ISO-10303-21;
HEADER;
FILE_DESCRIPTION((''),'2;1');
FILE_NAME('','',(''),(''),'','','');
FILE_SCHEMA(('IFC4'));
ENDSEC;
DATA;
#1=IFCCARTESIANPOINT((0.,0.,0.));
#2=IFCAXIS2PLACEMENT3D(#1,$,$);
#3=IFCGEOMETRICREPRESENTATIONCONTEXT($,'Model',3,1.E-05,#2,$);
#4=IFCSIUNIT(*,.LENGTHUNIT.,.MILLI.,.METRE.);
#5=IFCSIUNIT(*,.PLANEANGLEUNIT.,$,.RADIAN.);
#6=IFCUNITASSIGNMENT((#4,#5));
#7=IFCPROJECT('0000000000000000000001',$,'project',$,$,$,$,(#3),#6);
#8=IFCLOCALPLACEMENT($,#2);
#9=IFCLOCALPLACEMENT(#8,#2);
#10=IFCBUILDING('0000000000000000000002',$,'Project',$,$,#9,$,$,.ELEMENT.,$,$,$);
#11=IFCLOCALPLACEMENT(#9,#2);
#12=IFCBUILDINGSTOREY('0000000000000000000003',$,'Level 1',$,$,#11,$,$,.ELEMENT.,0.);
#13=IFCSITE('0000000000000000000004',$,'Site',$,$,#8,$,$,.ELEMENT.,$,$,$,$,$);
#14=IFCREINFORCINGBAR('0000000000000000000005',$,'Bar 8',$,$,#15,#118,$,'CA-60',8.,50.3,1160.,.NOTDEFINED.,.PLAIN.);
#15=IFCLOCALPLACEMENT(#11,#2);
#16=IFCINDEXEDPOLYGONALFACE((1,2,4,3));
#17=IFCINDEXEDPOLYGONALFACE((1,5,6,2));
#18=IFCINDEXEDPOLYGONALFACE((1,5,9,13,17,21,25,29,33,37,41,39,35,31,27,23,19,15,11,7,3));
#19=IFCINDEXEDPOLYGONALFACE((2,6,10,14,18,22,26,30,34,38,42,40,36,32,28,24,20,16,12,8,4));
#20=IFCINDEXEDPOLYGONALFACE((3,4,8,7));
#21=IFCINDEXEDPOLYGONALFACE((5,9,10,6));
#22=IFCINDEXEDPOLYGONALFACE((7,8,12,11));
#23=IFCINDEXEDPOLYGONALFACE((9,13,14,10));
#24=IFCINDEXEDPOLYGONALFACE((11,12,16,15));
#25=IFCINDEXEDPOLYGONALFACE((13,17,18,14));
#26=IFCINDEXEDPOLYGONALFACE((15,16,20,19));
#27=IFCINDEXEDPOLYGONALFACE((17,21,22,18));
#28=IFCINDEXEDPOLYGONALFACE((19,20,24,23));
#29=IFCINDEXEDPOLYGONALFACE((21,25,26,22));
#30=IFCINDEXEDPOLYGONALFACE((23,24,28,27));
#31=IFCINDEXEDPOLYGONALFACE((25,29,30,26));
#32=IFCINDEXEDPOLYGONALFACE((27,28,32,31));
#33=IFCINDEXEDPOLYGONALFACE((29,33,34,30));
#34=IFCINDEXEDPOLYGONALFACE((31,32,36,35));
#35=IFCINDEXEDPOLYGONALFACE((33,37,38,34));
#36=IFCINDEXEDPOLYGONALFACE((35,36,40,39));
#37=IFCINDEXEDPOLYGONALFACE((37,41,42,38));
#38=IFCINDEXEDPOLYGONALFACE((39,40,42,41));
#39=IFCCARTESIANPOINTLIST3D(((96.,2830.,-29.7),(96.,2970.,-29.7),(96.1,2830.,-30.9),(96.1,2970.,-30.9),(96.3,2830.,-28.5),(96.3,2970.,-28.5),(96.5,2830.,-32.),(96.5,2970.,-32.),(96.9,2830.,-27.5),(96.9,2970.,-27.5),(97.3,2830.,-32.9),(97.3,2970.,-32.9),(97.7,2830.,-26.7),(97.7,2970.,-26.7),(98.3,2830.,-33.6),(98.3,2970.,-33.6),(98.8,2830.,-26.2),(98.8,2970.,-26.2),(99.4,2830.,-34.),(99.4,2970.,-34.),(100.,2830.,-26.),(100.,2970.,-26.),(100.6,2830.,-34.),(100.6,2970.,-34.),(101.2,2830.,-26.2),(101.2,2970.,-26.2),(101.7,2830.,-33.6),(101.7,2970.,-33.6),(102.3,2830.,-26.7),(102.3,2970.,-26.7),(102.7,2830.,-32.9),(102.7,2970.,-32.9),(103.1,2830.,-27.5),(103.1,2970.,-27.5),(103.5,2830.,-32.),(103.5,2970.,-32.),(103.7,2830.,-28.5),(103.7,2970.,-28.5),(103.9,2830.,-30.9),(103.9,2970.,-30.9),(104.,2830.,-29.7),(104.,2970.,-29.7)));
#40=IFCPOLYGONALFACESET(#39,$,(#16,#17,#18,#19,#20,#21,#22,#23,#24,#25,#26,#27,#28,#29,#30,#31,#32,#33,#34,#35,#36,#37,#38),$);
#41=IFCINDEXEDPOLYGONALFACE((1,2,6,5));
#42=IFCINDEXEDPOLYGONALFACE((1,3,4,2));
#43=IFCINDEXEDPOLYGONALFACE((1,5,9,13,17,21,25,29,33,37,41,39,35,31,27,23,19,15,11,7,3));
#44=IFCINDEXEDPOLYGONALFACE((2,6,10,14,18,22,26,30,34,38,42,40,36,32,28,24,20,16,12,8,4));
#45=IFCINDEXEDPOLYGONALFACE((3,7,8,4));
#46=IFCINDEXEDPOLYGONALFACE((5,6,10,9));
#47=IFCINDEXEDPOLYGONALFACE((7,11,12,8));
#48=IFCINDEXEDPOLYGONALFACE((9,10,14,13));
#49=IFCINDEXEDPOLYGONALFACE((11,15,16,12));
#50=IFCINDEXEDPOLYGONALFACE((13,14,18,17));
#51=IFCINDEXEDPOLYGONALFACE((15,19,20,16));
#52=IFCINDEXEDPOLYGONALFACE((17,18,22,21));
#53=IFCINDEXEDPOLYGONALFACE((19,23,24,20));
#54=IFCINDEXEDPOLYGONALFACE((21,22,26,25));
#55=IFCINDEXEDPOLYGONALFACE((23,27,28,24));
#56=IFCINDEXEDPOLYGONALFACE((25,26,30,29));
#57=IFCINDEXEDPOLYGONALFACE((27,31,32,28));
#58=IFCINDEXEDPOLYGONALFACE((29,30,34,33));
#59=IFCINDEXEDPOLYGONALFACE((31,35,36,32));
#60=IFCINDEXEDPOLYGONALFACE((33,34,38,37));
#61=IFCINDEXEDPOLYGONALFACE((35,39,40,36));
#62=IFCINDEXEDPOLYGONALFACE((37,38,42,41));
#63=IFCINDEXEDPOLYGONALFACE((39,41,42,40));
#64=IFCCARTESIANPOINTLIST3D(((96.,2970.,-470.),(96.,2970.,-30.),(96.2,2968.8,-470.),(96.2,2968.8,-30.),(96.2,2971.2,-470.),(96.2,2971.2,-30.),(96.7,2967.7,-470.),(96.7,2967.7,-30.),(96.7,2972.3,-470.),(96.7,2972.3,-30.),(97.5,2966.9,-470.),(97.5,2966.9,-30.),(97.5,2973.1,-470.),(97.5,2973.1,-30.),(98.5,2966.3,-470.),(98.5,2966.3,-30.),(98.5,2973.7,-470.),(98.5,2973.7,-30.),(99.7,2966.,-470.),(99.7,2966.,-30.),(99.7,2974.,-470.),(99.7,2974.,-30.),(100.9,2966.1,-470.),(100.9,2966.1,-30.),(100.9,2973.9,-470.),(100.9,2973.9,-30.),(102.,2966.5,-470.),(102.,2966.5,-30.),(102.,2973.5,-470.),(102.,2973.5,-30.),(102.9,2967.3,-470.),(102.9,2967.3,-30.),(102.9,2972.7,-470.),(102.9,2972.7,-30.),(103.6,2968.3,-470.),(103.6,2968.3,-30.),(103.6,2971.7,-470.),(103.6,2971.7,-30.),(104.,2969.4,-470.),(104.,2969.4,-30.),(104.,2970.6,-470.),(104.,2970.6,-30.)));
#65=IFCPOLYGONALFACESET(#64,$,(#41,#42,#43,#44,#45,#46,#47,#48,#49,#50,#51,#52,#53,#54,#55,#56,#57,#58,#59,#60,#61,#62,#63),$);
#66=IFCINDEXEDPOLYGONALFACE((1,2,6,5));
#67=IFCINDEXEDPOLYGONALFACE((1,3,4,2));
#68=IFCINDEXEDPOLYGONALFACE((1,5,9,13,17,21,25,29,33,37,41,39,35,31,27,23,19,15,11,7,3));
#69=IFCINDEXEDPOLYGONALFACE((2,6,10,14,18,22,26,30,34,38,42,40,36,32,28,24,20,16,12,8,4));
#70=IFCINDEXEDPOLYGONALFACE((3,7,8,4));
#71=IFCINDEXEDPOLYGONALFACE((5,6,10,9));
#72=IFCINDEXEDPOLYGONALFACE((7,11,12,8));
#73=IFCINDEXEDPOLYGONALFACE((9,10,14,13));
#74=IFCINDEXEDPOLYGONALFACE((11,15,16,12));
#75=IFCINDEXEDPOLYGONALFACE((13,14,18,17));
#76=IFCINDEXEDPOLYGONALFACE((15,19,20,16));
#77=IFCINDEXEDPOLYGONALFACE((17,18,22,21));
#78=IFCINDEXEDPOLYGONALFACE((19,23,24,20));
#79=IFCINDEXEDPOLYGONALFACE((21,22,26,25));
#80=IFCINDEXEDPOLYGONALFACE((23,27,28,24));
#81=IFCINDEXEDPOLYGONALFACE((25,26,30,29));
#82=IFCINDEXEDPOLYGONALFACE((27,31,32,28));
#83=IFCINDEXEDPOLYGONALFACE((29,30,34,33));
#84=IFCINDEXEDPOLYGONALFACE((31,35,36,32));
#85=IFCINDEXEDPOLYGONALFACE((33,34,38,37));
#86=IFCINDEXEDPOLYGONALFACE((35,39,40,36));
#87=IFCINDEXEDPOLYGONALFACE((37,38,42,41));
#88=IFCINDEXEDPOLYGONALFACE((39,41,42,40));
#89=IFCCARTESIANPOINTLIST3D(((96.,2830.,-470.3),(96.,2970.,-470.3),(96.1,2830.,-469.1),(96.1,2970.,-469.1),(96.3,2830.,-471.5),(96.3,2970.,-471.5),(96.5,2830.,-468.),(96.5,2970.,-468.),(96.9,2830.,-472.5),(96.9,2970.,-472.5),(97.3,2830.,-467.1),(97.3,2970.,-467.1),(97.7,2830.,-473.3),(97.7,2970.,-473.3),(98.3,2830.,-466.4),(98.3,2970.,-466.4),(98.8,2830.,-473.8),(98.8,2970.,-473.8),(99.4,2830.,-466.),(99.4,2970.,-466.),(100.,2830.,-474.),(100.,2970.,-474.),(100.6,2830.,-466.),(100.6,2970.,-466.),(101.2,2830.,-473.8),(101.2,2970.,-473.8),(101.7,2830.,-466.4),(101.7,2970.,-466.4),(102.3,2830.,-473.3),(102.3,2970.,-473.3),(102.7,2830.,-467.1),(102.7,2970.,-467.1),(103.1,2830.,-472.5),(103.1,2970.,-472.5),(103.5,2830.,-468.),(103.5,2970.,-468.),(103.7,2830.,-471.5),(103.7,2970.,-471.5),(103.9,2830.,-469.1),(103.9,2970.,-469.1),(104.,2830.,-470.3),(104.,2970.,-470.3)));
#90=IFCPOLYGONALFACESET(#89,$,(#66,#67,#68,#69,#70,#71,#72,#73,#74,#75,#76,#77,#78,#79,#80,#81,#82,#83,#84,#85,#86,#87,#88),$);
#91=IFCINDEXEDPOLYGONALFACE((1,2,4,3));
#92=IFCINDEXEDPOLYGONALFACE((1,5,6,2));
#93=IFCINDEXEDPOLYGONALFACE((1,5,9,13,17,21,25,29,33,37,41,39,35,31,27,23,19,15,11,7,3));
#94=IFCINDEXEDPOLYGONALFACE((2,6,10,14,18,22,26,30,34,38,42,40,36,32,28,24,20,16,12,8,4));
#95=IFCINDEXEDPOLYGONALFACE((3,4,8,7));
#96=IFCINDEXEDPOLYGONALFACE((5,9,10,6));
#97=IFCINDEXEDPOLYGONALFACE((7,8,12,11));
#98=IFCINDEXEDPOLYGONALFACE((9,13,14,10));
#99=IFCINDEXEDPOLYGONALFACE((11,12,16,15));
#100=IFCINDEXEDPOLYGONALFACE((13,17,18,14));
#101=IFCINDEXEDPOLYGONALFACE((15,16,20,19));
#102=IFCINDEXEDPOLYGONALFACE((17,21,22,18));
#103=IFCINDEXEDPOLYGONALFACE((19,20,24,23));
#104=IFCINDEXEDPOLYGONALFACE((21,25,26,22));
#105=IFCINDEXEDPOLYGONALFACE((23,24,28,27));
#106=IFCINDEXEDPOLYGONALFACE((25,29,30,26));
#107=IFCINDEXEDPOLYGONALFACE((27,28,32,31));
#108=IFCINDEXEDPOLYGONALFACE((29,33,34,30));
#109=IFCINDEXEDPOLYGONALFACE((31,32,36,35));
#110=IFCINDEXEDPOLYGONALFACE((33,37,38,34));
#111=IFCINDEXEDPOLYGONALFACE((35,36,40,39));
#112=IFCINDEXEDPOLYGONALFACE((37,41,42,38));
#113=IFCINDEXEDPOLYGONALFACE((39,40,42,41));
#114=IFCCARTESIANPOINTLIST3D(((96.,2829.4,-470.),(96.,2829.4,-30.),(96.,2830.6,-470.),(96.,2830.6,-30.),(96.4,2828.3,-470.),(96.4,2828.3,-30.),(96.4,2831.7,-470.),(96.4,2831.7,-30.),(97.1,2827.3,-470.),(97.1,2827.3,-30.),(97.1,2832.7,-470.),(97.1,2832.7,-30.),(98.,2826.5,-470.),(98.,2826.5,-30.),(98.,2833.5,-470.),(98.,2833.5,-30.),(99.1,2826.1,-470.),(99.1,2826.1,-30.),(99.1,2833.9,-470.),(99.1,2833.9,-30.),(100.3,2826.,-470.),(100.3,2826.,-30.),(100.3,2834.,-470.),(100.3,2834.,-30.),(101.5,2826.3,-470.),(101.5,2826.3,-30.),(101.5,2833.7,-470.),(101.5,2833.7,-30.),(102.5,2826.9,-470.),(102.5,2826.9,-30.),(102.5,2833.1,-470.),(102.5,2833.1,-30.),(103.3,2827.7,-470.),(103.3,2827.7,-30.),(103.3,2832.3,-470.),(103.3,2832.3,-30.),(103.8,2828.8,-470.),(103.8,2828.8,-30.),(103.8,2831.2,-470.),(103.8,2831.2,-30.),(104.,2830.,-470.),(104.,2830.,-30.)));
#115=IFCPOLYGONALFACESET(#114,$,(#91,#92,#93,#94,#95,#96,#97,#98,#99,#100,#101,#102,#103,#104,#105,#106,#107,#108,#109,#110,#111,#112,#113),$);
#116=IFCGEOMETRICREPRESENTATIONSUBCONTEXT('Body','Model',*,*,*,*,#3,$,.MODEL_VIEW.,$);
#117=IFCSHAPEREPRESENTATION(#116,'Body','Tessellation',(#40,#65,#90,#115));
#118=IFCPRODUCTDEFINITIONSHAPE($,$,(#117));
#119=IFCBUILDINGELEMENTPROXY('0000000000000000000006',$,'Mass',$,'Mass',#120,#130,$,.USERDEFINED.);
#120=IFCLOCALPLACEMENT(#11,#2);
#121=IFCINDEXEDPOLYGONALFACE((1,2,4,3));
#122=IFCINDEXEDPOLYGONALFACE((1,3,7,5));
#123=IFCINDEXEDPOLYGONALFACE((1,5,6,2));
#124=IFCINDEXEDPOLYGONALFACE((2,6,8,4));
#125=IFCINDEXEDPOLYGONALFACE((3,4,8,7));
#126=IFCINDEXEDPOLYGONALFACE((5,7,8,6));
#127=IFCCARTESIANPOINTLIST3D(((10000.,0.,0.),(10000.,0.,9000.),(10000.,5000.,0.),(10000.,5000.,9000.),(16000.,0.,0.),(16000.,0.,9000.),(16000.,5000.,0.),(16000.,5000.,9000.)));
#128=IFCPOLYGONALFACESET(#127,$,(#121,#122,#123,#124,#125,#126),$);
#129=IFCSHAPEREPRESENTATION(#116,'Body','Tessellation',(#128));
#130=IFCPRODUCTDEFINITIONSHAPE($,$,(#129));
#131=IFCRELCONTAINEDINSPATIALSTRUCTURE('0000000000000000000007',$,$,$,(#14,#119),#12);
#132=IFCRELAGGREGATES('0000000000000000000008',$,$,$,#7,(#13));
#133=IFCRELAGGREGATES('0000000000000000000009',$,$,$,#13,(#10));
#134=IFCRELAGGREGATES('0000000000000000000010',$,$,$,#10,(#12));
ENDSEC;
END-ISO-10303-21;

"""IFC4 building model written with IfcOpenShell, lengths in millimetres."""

from ifc_helpers import new_model, entity, si_unit, origin, place, context, subcontext, project, spatial, polyline, outline, extrude, element, save


model = new_model("IFC4")

# Units and contexts
model_context = context("Model", 3, precision=1e-05, world=origin())
body_context = subcontext(model_context, "Body", "Model", "MODEL_VIEW")
ifc_project = project(units=[si_unit("LENGTHUNIT", "METRE", prefix="MILLI"), si_unit("PLANEANGLEUNIT", "RADIAN")], contexts=[model_context])

# Site, building, storey
site_placement = place(None, origin())
site = spatial("IfcSite", under=ifc_project, at=site_placement, Name="Site", CompositionType="ELEMENT")
building_placement = place(site_placement, origin())
building = spatial("IfcBuilding", under=site, at=building_placement, Name="Project", CompositionType="ELEMENT")
storey_placement = place(building_placement, origin())
storey = spatial("IfcBuildingStorey", under=building, at=storey_placement, Name="Level 1", CompositionType="ELEMENT", Elevation=0.0)

# Reinforcing bar
reinforcing_bar_1_placement = place(storey_placement, origin())
element("IfcReinforcingBar", 1, at=reinforcing_bar_1_placement, inside=storey, Name="Bar 8", SteelGrade="CA-60", BarLength=1160.0, BarSurface="PLAIN", CrossSectionArea=50.3, NominalDiameter=8.0, PredefinedType="NOTDEFINED", context=body_context, shape_type="AdvancedSweptSolid", body=[
    entity("IfcSweptDiskSolid", entity("IfcPolyline", [entity("IfcCartesianPoint", [100.0, 2830.0, -30.0]), entity("IfcCartesianPoint", [100.0, 2970.0, -30.0])]), 4.0),
    entity("IfcSweptDiskSolid", entity("IfcPolyline", [entity("IfcCartesianPoint", [100.0, 2970.0, -30.0]), entity("IfcCartesianPoint", [100.0, 2970.0, -470.0])]), 4.0),
    entity("IfcSweptDiskSolid", entity("IfcPolyline", [entity("IfcCartesianPoint", [100.0, 2970.0, -470.0]), entity("IfcCartesianPoint", [100.0, 2830.0, -470.0])]), 4.0),
    entity("IfcSweptDiskSolid", entity("IfcPolyline", [entity("IfcCartesianPoint", [100.0, 2830.0, -470.0]), entity("IfcCartesianPoint", [100.0, 2830.0, -30.0])]), 4.0),
])

# Building element proxy
proxy_placement = place(storey_placement, origin())
element("IfcBuildingElementProxy", 2, at=proxy_placement, inside=storey, Name="Mass", ObjectType="Mass", PredefinedType="USERDEFINED", context=body_context, shape_type="SweptSolid", body=[
    extrude(outline(polyline([(10000.0, 0.0), (16000.0, 0.0), (16000.0, 5000.0), (10000.0, 5000.0), (10000.0, 0.0)])), origin(), (0.0, 0.0, 1.0), 9000.0),
])

save(model, "model.ifc")
